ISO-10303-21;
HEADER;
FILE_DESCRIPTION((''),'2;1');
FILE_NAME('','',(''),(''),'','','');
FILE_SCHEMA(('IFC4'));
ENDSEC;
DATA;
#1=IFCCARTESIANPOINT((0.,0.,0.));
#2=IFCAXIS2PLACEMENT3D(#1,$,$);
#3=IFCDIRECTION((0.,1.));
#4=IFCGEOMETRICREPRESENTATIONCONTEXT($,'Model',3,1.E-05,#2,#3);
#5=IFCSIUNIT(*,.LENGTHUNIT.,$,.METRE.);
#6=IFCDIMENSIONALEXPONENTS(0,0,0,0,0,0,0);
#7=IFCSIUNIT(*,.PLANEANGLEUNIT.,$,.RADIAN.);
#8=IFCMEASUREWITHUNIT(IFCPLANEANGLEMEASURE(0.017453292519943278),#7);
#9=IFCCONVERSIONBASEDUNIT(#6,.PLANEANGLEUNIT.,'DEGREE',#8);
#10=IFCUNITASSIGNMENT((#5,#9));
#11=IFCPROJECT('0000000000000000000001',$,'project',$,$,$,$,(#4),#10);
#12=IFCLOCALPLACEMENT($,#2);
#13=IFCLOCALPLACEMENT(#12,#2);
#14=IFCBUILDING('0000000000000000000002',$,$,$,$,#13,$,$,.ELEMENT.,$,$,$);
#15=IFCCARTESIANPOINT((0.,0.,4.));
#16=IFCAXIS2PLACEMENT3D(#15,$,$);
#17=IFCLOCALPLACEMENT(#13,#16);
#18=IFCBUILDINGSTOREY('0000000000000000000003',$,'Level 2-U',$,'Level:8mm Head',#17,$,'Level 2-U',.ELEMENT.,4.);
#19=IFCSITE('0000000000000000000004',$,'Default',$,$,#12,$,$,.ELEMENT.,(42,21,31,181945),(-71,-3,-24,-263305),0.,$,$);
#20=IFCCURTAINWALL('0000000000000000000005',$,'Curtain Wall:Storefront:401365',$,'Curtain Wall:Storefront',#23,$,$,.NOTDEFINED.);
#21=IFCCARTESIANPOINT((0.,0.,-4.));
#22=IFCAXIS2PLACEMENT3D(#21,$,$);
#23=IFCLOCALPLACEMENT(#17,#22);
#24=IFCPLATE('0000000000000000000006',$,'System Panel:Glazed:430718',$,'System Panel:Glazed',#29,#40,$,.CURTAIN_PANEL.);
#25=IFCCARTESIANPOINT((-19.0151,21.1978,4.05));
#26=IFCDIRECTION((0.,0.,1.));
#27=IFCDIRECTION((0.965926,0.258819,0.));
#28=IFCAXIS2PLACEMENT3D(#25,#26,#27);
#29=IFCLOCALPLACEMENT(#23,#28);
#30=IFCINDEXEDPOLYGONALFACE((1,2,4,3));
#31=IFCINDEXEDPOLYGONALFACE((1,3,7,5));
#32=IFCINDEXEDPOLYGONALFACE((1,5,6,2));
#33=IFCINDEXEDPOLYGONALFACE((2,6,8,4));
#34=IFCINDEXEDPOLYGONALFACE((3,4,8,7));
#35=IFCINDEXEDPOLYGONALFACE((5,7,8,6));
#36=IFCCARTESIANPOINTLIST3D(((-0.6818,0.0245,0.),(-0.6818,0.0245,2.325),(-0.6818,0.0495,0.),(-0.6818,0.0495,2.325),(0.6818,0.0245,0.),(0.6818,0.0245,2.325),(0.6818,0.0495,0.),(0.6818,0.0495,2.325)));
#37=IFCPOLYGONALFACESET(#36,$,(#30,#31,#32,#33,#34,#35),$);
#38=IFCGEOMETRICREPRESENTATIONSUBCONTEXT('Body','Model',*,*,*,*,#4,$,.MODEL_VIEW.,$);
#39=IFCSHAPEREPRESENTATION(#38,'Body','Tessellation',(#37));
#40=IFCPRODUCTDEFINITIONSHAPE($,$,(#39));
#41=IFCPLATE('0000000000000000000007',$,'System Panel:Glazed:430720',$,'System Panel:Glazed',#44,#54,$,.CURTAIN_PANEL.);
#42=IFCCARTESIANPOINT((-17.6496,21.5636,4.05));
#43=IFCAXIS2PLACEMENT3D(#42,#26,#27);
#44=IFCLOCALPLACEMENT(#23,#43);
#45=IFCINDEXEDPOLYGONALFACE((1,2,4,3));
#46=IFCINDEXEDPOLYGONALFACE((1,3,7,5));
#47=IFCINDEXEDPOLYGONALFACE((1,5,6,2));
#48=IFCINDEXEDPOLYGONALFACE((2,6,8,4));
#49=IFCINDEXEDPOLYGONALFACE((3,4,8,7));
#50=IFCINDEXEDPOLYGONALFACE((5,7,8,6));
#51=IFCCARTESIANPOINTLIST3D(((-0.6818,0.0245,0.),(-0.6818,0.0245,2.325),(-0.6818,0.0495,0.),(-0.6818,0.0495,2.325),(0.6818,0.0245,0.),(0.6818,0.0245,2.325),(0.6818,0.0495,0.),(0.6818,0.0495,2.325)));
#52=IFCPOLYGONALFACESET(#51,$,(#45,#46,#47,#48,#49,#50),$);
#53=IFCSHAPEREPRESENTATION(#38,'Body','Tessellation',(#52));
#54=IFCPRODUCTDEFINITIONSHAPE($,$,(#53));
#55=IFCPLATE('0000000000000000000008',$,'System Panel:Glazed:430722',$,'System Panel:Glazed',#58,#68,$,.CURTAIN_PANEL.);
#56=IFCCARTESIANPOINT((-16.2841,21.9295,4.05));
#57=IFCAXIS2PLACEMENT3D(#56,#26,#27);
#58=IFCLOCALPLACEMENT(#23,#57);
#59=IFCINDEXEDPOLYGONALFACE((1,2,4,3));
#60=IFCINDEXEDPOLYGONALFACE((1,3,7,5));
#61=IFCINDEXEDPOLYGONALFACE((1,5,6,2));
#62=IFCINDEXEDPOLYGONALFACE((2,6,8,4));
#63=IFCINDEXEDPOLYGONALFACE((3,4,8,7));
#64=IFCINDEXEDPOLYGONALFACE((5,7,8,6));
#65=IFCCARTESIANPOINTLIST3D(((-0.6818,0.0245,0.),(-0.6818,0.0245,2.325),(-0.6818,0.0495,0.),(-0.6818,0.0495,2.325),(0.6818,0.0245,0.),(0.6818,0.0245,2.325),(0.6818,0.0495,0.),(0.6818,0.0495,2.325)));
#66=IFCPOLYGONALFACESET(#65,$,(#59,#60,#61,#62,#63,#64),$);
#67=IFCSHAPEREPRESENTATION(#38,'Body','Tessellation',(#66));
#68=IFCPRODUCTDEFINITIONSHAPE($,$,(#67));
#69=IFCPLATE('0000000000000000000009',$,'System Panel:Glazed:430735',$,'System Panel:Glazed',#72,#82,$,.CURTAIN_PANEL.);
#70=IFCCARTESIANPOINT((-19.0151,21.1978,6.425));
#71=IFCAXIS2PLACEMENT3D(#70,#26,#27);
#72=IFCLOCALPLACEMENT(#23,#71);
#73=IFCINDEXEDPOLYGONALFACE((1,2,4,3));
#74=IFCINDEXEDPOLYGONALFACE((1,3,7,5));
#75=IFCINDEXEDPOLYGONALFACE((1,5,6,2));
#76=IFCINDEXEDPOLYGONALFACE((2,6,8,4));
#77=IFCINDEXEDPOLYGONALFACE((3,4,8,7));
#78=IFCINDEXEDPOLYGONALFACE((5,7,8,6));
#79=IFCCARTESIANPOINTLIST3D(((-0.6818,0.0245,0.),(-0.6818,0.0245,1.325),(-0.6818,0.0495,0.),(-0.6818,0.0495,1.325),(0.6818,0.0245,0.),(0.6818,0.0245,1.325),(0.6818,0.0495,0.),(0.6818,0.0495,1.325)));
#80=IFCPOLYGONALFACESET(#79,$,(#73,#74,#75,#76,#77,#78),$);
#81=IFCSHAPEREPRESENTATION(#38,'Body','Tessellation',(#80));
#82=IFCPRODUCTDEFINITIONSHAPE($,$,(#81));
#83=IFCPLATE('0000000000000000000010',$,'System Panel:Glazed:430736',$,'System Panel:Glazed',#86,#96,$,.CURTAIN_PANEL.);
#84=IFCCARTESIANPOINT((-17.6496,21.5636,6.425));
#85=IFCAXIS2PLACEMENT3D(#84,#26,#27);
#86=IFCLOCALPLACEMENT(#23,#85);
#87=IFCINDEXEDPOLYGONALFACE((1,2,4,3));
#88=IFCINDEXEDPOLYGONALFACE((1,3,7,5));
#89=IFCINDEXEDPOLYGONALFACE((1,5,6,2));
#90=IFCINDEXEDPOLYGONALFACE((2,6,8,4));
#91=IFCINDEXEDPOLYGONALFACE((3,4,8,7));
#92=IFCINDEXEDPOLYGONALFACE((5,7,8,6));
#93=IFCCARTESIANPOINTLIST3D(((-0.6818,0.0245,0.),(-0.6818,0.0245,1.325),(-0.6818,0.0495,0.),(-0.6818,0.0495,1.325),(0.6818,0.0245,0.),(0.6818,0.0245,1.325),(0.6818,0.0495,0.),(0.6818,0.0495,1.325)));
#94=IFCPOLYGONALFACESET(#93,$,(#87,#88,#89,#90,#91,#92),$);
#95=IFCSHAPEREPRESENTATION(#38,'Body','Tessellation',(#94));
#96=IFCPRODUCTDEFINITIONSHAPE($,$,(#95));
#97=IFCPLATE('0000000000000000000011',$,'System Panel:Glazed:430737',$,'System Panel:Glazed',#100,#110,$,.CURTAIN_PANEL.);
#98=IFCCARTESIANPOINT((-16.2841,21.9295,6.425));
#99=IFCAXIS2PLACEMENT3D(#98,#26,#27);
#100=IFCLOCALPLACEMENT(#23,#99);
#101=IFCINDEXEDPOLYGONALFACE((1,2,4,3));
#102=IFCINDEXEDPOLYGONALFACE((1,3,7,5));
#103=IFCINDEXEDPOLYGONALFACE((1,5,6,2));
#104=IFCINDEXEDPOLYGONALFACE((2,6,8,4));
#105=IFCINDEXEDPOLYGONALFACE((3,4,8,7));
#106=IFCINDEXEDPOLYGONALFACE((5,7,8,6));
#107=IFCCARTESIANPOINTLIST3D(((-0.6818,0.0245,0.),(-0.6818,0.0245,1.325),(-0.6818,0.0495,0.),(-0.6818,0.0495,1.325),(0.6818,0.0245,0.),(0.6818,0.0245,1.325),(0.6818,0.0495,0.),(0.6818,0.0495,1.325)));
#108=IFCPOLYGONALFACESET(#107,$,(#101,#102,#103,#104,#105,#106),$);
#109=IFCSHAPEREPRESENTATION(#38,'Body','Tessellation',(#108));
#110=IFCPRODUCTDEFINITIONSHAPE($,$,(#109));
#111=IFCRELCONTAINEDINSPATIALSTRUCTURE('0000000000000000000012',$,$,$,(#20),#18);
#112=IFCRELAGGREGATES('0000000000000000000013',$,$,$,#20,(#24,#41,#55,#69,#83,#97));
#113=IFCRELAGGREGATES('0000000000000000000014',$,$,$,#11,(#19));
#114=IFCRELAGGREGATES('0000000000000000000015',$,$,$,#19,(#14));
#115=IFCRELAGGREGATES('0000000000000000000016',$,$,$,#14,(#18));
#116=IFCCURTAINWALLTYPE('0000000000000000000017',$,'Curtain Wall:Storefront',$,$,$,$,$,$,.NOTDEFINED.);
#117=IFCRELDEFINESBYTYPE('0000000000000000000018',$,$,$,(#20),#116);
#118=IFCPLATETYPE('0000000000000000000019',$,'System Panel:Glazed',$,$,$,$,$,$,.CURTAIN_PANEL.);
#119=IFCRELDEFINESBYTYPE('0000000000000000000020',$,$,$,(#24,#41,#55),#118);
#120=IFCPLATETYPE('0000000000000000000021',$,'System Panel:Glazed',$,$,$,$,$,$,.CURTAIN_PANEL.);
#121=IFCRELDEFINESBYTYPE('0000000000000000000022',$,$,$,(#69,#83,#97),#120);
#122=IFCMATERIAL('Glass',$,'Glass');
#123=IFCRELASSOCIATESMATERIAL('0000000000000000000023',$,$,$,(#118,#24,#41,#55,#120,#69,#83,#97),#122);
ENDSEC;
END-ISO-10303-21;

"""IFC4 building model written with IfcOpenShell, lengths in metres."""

from ifc_helpers import new_model, entity, si_unit, converted_unit, direction, frame, origin, place, context, subcontext, project, spatial, indexed_curve, outline, extrude, source, transform, mapped, material, type_object, type_shapes, element, aggregate, save


model = new_model("IFC4")

# Units and contexts
model_context = context("Model", 3, precision=1e-05, world=origin(), true_north=direction((0.0, 1.0)))
body_context = subcontext(model_context, "Body", "Model", "MODEL_VIEW")
ifc_project = project(units=[si_unit("LENGTHUNIT", "METRE"), converted_unit("PLANEANGLEUNIT", "DEGREE", entity("IfcPlaneAngleMeasure", 0.017453292519943278), si_unit("PLANEANGLEUNIT", "RADIAN"), dimensions=[0, 0, 0, 0, 0, 0, 0])], contexts=[model_context])

# Site, building, storey
site_placement = place(None, origin())
site = spatial("IfcSite", under=ifc_project, at=site_placement, Name="Default", CompositionType="ELEMENT", RefLatitude=(42, 21, 31, 181945), RefLongitude=(-71, -3, -24, -263305), RefElevation=0.0)
building_placement = place(site_placement, origin())
building = spatial("IfcBuilding", under=site, at=building_placement, CompositionType="ELEMENT")
storey_placement = place(building_placement, frame((0.0, 0.0, 4.0)))
storey = spatial("IfcBuildingStorey", under=building, at=storey_placement, Name="Level 2-U", ObjectType="Level:8mm Head", LongName="Level 2-U", CompositionType="ELEMENT", Elevation=4.0)

# Curtain wall, plates
curtain_wall_type = type_object("IfcCurtainWallType", Name="Curtain Wall:Storefront", PredefinedType="NOTDEFINED")
curtain_wall_placement = place(storey_placement, frame((0.0, 0.0, -4.0)))
curtain_wall = element("IfcCurtainWall", 1, at=curtain_wall_placement, inside=storey, type_object=curtain_wall_type, Name="Curtain Wall:Storefront:401365", ObjectType="Curtain Wall:Storefront", PredefinedType="NOTDEFINED")
ifc_material_1 = material(Name="Glass", Category="Glass")
plate_type_1 = type_object("IfcPlateType", Name="System Panel:Glazed", PredefinedType="CURTAIN_PANEL", material=ifc_material_1)
shared_shape_1 = source(origin(), body_context, "Body", "SweptSolid", [
    extrude(outline(indexed_curve([(-0.0125, -0.6818), (0.0125, -0.6818), (0.0125, 0.6818), (-0.0125, 0.6818), (-0.0125, -0.6818)], self_intersect=False)), frame((0.0, 0.037, 0.0), z_axis=(0.0, 0.0, 1.0), x_axis=(0.0, 1.0, 0.0)), (0.0, 0.0, 1.0), 2.325),
])
type_shapes(plate_type_1, [shared_shape_1])
plate_1_placement = place(curtain_wall_placement, frame((-19.0151, 21.1978, 4.05), z_axis=(0.0, 0.0, 1.0), x_axis=(0.965926, 0.258819, 0.0)))
plate_1 = element("IfcPlate", 2, at=plate_1_placement, type_object=plate_type_1, material=ifc_material_1, Name="System Panel:Glazed:430718", ObjectType="System Panel:Glazed", PredefinedType="CURTAIN_PANEL", context=body_context, shape_type="MappedRepresentation", body=[
    mapped(shared_shape_1, transform((0.0, 0.0, 0.0), scale=1.0)),
])
plate_2_placement = place(curtain_wall_placement, frame((-17.6496, 21.5636, 4.05), z_axis=(0.0, 0.0, 1.0), x_axis=(0.965926, 0.258819, 0.0)))
plate_2 = element("IfcPlate", 3, at=plate_2_placement, type_object=plate_type_1, material=ifc_material_1, Name="System Panel:Glazed:430720", ObjectType="System Panel:Glazed", PredefinedType="CURTAIN_PANEL", context=body_context, shape_type="MappedRepresentation", body=[
    mapped(shared_shape_1, transform((0.0, 0.0, 0.0), scale=1.0)),
])
plate_3_placement = place(curtain_wall_placement, frame((-16.2841, 21.9295, 4.05), z_axis=(0.0, 0.0, 1.0), x_axis=(0.965926, 0.258819, 0.0)))
plate_3 = element("IfcPlate", 4, at=plate_3_placement, type_object=plate_type_1, material=ifc_material_1, Name="System Panel:Glazed:430722", ObjectType="System Panel:Glazed", PredefinedType="CURTAIN_PANEL", context=body_context, shape_type="MappedRepresentation", body=[
    mapped(shared_shape_1, transform((0.0, 0.0, 0.0), scale=1.0)),
])
plate_type_2 = type_object("IfcPlateType", Name="System Panel:Glazed", PredefinedType="CURTAIN_PANEL", material=ifc_material_1)
shared_shape_2 = source(origin(), body_context, "Body", "SweptSolid", [
    extrude(outline(indexed_curve([(-0.0125, -0.6818), (0.0125, -0.6818), (0.0125, 0.6818), (-0.0125, 0.6818), (-0.0125, -0.6818)], self_intersect=False)), frame((0.0, 0.037, 0.0), z_axis=(0.0, 0.0, 1.0), x_axis=(0.0, 1.0, 0.0)), (0.0, 0.0, 1.0), 1.325),
])
type_shapes(plate_type_2, [shared_shape_2])
plate_4_placement = place(curtain_wall_placement, frame((-19.0151, 21.1978, 6.425), z_axis=(0.0, 0.0, 1.0), x_axis=(0.965926, 0.258819, 0.0)))
plate_4 = element("IfcPlate", 5, at=plate_4_placement, type_object=plate_type_2, material=ifc_material_1, Name="System Panel:Glazed:430735", ObjectType="System Panel:Glazed", PredefinedType="CURTAIN_PANEL", context=body_context, shape_type="MappedRepresentation", body=[
    mapped(shared_shape_2, transform((0.0, 0.0, 0.0), scale=1.0)),
])
plate_5_placement = place(curtain_wall_placement, frame((-17.6496, 21.5636, 6.425), z_axis=(0.0, 0.0, 1.0), x_axis=(0.965926, 0.258819, 0.0)))
plate_5 = element("IfcPlate", 6, at=plate_5_placement, type_object=plate_type_2, material=ifc_material_1, Name="System Panel:Glazed:430736", ObjectType="System Panel:Glazed", PredefinedType="CURTAIN_PANEL", context=body_context, shape_type="MappedRepresentation", body=[
    mapped(shared_shape_2, transform((0.0, 0.0, 0.0), scale=1.0)),
])
plate_6_placement = place(curtain_wall_placement, frame((-16.2841, 21.9295, 6.425), z_axis=(0.0, 0.0, 1.0), x_axis=(0.965926, 0.258819, 0.0)))
plate_6 = element("IfcPlate", 7, at=plate_6_placement, type_object=plate_type_2, material=ifc_material_1, Name="System Panel:Glazed:430737", ObjectType="System Panel:Glazed", PredefinedType="CURTAIN_PANEL", context=body_context, shape_type="MappedRepresentation", body=[
    mapped(shared_shape_2, transform((0.0, 0.0, 0.0), scale=1.0)),
])
aggregate(curtain_wall, [plate_1, plate_2, plate_3, plate_4, plate_5, plate_6])

save(model, "model.ifc")
